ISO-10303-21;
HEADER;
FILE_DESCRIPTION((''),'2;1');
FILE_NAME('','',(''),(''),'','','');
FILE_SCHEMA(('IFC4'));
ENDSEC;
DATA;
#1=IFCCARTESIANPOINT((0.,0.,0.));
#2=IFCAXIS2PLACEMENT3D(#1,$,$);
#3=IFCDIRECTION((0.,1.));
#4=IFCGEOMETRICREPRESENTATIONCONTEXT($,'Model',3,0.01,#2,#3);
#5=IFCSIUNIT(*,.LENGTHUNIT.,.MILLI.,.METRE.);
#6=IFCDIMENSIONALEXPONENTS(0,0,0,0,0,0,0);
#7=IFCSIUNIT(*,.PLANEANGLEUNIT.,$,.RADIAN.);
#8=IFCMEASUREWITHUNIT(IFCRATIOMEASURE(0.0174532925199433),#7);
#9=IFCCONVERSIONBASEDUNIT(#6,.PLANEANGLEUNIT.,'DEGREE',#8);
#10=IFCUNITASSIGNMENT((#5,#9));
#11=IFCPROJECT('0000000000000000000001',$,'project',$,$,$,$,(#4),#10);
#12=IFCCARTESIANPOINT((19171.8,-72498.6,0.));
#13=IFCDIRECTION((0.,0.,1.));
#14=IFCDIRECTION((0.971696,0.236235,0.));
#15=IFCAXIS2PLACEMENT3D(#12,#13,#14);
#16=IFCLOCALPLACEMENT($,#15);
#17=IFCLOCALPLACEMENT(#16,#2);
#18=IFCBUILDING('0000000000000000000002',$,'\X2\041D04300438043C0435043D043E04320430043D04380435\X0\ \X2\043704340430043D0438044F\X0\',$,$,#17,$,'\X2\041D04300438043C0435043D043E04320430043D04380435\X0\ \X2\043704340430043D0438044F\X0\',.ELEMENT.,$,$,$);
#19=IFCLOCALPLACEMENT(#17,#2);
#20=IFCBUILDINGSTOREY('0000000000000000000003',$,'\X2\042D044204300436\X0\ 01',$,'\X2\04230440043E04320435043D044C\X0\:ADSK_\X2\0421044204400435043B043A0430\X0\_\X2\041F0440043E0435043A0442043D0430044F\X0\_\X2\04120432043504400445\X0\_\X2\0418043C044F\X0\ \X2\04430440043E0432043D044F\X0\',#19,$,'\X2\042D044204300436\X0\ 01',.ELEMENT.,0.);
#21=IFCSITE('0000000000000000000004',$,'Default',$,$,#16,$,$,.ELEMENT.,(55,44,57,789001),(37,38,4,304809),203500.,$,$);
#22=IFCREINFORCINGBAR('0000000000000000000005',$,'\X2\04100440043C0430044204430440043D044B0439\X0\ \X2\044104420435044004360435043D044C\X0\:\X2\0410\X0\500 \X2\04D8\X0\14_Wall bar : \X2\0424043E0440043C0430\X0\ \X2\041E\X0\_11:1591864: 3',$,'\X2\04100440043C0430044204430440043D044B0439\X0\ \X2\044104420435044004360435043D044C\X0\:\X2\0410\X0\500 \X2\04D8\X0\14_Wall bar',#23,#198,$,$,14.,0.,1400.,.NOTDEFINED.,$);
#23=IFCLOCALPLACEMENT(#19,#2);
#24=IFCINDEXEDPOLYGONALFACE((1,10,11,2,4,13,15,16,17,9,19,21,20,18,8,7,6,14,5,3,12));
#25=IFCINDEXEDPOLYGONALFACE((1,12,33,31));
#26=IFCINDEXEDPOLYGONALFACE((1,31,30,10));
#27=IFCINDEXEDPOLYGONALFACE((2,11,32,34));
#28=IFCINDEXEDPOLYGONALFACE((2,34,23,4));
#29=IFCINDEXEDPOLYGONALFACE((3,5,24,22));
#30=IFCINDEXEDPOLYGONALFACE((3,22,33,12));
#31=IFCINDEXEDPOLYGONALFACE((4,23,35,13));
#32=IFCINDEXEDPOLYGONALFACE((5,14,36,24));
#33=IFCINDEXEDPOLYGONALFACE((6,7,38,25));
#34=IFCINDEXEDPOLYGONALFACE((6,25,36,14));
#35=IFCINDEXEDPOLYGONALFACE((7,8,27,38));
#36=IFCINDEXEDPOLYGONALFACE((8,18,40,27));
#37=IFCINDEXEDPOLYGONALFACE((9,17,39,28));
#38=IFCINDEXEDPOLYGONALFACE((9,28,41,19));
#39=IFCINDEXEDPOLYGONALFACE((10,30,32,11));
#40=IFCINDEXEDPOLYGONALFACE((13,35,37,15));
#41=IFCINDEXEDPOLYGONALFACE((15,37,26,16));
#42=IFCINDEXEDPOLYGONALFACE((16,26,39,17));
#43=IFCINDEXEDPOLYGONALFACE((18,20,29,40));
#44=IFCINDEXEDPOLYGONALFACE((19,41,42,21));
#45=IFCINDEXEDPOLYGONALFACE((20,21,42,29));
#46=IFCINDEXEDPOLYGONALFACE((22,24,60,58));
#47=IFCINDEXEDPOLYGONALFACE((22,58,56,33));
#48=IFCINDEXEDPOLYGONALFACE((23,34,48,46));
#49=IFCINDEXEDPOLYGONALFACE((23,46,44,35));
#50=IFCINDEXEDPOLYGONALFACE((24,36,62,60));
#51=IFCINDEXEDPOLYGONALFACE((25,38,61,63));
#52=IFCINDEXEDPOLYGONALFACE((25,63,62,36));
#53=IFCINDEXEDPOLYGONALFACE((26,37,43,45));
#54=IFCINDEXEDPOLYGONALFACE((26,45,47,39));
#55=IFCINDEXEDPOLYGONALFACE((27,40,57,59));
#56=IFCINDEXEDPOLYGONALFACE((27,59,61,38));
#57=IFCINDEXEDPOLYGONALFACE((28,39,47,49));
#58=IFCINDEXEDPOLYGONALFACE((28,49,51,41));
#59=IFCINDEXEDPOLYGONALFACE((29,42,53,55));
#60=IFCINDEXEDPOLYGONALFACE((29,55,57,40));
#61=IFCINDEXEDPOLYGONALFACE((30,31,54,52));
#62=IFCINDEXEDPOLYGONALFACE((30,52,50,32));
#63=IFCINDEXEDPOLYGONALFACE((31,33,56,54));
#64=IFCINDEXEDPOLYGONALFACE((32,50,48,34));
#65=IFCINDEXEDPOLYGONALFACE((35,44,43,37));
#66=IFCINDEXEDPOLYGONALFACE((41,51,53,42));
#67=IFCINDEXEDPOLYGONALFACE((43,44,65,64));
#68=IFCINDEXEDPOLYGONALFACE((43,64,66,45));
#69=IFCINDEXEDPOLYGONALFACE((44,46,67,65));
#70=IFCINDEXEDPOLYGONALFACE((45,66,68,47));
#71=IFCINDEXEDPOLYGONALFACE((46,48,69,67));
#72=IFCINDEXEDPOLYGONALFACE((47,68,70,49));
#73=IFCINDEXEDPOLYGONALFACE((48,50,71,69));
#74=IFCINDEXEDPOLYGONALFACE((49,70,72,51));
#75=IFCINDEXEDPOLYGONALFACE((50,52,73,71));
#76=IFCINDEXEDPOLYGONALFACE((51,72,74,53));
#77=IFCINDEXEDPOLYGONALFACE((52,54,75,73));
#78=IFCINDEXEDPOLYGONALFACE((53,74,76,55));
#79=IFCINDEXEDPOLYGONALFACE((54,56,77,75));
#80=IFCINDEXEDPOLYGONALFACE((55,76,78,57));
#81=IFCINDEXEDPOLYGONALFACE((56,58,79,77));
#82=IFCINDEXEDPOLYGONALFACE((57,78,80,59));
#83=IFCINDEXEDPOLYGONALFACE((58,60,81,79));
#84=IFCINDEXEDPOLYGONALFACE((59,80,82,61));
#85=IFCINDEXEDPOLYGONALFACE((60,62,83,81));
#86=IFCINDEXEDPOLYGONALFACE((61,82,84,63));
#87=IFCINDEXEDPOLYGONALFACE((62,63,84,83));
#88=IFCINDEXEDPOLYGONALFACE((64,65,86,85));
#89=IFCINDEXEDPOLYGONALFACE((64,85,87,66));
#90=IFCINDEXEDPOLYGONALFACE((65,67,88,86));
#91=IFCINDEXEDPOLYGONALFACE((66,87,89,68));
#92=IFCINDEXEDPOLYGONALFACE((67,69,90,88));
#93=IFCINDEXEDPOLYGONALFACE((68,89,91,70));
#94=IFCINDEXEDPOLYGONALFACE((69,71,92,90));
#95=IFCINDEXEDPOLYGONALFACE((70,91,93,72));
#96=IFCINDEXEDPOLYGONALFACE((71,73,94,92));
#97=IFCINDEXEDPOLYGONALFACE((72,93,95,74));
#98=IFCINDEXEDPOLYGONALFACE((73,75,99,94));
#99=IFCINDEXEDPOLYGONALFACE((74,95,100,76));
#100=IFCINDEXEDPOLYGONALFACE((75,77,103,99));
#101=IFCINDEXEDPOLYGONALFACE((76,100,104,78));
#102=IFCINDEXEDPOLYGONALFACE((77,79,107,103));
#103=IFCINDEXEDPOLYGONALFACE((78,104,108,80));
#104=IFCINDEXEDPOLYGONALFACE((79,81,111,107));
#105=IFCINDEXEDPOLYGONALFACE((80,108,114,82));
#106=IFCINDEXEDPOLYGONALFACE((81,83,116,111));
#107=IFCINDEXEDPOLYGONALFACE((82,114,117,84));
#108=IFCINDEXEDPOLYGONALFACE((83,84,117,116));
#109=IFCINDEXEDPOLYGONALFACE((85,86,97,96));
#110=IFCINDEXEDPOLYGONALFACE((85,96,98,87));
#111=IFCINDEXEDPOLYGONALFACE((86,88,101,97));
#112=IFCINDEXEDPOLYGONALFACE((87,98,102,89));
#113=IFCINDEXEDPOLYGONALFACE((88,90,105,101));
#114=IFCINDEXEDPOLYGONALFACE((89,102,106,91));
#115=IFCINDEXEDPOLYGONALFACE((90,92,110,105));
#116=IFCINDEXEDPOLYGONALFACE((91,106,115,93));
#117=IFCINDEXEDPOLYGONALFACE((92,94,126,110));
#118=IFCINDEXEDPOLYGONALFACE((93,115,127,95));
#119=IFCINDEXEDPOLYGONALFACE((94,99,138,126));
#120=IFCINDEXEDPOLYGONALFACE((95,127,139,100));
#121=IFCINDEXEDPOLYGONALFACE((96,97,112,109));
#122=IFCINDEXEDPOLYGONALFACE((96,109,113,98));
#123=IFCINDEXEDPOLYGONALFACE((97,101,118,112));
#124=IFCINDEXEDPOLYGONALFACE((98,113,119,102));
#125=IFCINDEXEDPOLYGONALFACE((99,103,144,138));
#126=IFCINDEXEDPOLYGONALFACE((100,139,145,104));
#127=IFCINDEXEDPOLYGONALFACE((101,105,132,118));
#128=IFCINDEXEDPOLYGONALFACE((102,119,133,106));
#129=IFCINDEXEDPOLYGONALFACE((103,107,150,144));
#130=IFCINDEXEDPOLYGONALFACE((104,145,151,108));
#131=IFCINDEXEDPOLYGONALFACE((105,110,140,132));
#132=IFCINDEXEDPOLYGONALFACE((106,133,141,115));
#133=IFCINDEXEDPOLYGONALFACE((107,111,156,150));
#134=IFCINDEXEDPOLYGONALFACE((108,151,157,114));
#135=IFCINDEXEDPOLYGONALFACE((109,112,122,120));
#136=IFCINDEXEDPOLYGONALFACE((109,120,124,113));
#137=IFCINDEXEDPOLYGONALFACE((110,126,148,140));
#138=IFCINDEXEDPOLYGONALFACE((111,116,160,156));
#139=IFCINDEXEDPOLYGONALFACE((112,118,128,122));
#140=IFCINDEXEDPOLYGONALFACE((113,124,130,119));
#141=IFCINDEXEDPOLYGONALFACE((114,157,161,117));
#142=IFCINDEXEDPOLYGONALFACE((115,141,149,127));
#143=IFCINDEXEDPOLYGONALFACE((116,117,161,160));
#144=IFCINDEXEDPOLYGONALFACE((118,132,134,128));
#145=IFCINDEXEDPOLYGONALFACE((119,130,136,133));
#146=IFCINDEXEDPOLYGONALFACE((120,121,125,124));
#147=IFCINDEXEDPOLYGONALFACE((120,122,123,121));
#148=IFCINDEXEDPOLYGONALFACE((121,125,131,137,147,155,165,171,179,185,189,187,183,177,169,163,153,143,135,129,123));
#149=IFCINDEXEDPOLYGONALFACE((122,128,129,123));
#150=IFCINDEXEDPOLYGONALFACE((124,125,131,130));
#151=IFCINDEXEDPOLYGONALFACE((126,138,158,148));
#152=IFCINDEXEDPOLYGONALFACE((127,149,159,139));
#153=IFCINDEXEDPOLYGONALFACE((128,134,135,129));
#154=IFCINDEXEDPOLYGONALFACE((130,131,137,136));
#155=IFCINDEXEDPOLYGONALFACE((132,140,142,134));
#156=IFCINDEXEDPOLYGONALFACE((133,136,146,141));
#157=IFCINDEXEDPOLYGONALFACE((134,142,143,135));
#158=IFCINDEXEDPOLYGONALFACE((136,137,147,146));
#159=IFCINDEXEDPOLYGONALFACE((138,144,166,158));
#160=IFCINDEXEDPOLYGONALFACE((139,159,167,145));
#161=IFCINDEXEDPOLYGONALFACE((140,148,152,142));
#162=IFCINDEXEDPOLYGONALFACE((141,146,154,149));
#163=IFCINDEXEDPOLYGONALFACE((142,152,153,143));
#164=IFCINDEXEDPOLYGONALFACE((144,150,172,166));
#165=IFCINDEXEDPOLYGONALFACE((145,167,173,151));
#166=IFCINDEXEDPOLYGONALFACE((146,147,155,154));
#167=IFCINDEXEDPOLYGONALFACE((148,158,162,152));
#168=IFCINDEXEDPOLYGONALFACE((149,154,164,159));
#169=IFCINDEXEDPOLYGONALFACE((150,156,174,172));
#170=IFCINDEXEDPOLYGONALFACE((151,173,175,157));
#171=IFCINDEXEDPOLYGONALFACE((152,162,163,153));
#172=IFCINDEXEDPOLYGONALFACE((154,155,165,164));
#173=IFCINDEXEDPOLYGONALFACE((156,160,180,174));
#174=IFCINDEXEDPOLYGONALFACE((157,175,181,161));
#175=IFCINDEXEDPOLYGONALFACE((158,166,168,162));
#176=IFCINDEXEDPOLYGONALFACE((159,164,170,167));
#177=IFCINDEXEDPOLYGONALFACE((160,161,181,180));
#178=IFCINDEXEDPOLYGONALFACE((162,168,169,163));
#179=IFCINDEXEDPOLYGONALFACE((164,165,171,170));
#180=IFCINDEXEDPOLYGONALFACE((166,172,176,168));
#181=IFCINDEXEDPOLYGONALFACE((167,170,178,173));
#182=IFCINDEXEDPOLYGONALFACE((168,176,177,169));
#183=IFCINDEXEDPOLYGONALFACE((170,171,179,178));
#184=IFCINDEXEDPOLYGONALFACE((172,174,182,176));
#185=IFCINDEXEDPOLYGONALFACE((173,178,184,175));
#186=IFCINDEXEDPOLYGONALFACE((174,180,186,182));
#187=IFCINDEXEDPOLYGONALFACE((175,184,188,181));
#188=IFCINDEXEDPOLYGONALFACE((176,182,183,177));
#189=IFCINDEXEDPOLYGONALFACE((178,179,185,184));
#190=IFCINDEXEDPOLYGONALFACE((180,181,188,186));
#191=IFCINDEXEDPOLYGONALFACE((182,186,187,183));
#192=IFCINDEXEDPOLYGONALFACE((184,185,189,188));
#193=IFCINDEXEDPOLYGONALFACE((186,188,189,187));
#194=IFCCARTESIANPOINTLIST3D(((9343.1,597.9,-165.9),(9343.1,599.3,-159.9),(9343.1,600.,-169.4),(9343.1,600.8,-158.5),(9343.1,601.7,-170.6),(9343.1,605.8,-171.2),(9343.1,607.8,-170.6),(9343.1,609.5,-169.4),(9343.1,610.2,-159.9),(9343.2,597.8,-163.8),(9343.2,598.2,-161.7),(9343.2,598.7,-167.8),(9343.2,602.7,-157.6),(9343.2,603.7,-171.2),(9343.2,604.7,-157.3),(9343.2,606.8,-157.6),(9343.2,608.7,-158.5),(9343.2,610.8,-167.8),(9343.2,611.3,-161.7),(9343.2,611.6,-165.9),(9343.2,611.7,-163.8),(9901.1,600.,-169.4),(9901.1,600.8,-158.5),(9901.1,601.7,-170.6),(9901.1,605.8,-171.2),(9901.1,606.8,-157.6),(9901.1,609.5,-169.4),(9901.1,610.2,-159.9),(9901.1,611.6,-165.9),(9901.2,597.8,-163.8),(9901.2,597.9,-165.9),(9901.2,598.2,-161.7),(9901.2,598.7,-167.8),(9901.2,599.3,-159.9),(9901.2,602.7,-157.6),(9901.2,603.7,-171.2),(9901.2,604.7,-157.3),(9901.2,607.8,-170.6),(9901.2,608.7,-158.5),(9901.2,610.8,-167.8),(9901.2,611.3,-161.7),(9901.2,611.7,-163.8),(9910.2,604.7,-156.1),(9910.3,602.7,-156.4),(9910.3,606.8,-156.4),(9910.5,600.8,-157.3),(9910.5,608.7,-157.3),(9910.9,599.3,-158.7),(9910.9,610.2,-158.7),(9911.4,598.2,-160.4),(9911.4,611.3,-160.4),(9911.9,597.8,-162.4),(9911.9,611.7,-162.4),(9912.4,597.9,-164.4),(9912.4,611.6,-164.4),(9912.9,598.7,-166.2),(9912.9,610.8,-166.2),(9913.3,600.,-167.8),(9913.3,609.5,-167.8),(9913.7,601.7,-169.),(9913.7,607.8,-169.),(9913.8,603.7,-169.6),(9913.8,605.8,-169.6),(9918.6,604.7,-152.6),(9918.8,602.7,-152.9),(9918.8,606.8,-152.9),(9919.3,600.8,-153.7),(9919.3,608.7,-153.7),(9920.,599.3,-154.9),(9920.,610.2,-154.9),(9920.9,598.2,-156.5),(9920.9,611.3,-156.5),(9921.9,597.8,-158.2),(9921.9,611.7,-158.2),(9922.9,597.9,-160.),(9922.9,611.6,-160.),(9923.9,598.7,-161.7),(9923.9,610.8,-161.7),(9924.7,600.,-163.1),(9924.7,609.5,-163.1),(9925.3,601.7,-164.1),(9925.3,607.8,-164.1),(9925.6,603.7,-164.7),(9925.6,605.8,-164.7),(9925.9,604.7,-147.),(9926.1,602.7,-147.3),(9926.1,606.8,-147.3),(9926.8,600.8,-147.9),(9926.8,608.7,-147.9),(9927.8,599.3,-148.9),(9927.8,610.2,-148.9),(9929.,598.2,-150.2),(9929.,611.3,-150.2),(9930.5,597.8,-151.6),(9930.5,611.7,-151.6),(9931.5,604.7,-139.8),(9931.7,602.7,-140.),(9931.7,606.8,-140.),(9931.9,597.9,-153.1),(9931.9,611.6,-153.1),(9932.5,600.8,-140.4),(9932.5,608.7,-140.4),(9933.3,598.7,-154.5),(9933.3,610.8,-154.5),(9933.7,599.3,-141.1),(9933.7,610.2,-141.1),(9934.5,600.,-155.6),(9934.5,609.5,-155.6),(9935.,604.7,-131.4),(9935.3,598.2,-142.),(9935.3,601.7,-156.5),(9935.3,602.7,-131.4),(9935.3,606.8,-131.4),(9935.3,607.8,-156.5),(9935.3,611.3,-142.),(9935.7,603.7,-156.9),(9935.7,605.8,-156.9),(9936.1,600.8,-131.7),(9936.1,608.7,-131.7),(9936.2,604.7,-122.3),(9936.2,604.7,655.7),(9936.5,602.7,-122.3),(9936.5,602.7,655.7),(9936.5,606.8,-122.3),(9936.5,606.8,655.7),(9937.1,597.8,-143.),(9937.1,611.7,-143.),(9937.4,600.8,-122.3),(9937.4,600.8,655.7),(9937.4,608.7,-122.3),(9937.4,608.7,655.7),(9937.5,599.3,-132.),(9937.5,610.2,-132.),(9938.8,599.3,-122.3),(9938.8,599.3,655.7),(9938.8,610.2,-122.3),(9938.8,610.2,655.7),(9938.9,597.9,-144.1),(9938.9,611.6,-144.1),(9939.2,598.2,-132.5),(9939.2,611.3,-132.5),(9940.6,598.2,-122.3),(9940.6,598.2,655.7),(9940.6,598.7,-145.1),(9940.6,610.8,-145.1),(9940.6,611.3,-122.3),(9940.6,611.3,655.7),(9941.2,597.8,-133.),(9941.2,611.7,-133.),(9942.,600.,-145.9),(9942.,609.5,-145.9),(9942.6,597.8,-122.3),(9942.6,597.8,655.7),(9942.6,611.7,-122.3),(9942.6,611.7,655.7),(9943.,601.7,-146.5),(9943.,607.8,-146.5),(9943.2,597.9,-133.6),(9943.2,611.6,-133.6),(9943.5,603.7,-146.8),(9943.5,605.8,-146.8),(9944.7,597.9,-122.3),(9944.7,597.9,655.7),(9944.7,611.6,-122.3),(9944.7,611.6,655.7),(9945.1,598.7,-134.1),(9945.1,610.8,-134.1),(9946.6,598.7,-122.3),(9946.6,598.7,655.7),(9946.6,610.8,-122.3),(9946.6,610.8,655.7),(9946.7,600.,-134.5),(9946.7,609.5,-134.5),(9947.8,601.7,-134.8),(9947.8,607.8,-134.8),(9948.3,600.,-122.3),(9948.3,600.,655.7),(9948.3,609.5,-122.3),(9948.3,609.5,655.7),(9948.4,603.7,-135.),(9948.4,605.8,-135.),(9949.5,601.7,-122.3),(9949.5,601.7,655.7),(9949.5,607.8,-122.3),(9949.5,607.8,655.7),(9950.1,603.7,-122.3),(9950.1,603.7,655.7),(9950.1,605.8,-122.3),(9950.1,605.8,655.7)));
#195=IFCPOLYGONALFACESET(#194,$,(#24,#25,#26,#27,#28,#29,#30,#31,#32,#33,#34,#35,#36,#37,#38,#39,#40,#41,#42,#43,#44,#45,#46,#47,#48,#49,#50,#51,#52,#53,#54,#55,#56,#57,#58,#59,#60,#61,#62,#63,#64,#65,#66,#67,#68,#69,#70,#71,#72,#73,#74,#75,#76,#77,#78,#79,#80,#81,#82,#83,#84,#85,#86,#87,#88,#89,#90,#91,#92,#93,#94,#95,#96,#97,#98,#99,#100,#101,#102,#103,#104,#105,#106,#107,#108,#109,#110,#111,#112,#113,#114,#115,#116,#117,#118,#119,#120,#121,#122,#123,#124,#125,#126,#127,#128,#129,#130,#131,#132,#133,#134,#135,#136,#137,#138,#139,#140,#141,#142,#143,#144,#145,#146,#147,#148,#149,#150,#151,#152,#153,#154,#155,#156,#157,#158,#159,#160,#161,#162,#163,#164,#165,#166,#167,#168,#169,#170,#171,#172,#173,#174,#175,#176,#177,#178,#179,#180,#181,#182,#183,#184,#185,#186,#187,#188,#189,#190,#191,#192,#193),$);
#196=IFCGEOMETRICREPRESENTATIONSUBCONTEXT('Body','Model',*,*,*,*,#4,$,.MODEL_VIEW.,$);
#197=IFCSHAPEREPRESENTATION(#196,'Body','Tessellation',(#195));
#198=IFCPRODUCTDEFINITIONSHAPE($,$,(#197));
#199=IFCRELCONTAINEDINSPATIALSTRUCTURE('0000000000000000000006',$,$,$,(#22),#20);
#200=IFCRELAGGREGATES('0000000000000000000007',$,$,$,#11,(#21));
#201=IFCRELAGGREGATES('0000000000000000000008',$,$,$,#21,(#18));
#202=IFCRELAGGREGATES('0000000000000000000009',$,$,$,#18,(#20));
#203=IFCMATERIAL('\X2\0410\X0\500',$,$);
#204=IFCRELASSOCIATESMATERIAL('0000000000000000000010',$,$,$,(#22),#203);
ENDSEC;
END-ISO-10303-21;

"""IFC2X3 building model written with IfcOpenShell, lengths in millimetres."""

from ifc_helpers import new_model, entity, si_unit, converted_unit, direction, frame, origin, place, context, subcontext, project, spatial, material, element, save


model = new_model("IFC2X3")

# Units and contexts
model_context = context("Model", 3, precision=0.01, world=origin(), true_north=direction((0.0, 1.0)))
body_context = subcontext(model_context, "Body", "Model", "MODEL_VIEW")
ifc_project = project(units=[si_unit("LENGTHUNIT", "METRE", prefix="MILLI"), converted_unit("PLANEANGLEUNIT", "DEGREE", entity("IfcRatioMeasure", 0.0174532925199433), si_unit("PLANEANGLEUNIT", "RADIAN"), dimensions=[0, 0, 0, 0, 0, 0, 0])], contexts=[model_context])

# Site, building, storey
site_placement = place(None, frame((19171.8, -72498.6, 0.0), z_axis=(0.0, 0.0, 1.0), x_axis=(0.971696, 0.236235, 0.0)))
site = spatial("IfcSite", under=ifc_project, at=site_placement, Name="Default", CompositionType="ELEMENT", RefLatitude=(55, 44, 57, 789001), RefLongitude=(37, 38, 4, 304809), RefElevation=203500.0)
building_placement = place(site_placement, origin())
building = spatial("IfcBuilding", under=site, at=building_placement, Name="Наименование здания", LongName="Наименование здания", CompositionType="ELEMENT")
storey_placement = place(building_placement, origin())
storey = spatial("IfcBuildingStorey", under=building, at=storey_placement, Name="Этаж 01", ObjectType="Уровень:ADSK_Стрелка_Проектная_Вверх_Имя уровня", LongName="Этаж 01", CompositionType="ELEMENT", Elevation=0.0)

# Reinforcing bar
ifc_material = material(Name="А500")
placement = place(storey_placement, origin())
element("IfcReinforcingBar", 1, at=placement, inside=storey, material=ifc_material, Name="Арматурный стержень:А500 Ә14_Wall bar : Форма О_11:1591864: 3", ObjectType="Арматурный стержень:А500 Ә14_Wall bar", BarLength=1400.0, BarRole="NOTDEFINED", CrossSectionArea=0.0, NominalDiameter=14.0, context=body_context, shape_type="AdvancedSweptSolid", body=[
    entity("IfcSweptDiskSolid", entity("IfcCompositeCurve", [entity("IfcCompositeCurveSegment", "CONTINUOUS", True, entity("IfcPolyline", [entity("IfcCartesianPoint", [9943.1, 604.7, 655.7]), entity("IfcCartesianPoint", [9943.1, 604.7, -122.3])])), entity("IfcCompositeCurveSegment", "CONTINUOUS", True, entity("IfcTrimmedCurve", entity("IfcCircle", entity("IfcAxis2Placement3D", entity("IfcCartesianPoint", [9901.1, 604.7, -122.3]), entity("IfcDirection", [0.0, 1.0, 0.0]), entity("IfcDirection", [0.0, 0.0, -1.0])), 42.0), [entity("IfcParameterValue", 270.0)], [entity("IfcParameterValue", 360.0)], True, "PARAMETER")), entity("IfcCompositeCurveSegment", "CONTINUOUS", True, entity("IfcPolyline", [entity("IfcCartesianPoint", [9901.1, 604.7, -164.3]), entity("IfcCartesianPoint", [9343.1, 604.7, -164.3])]))], False), 7.0, None, 0.0, 92.0),
])

save(model, "model.ifc")
